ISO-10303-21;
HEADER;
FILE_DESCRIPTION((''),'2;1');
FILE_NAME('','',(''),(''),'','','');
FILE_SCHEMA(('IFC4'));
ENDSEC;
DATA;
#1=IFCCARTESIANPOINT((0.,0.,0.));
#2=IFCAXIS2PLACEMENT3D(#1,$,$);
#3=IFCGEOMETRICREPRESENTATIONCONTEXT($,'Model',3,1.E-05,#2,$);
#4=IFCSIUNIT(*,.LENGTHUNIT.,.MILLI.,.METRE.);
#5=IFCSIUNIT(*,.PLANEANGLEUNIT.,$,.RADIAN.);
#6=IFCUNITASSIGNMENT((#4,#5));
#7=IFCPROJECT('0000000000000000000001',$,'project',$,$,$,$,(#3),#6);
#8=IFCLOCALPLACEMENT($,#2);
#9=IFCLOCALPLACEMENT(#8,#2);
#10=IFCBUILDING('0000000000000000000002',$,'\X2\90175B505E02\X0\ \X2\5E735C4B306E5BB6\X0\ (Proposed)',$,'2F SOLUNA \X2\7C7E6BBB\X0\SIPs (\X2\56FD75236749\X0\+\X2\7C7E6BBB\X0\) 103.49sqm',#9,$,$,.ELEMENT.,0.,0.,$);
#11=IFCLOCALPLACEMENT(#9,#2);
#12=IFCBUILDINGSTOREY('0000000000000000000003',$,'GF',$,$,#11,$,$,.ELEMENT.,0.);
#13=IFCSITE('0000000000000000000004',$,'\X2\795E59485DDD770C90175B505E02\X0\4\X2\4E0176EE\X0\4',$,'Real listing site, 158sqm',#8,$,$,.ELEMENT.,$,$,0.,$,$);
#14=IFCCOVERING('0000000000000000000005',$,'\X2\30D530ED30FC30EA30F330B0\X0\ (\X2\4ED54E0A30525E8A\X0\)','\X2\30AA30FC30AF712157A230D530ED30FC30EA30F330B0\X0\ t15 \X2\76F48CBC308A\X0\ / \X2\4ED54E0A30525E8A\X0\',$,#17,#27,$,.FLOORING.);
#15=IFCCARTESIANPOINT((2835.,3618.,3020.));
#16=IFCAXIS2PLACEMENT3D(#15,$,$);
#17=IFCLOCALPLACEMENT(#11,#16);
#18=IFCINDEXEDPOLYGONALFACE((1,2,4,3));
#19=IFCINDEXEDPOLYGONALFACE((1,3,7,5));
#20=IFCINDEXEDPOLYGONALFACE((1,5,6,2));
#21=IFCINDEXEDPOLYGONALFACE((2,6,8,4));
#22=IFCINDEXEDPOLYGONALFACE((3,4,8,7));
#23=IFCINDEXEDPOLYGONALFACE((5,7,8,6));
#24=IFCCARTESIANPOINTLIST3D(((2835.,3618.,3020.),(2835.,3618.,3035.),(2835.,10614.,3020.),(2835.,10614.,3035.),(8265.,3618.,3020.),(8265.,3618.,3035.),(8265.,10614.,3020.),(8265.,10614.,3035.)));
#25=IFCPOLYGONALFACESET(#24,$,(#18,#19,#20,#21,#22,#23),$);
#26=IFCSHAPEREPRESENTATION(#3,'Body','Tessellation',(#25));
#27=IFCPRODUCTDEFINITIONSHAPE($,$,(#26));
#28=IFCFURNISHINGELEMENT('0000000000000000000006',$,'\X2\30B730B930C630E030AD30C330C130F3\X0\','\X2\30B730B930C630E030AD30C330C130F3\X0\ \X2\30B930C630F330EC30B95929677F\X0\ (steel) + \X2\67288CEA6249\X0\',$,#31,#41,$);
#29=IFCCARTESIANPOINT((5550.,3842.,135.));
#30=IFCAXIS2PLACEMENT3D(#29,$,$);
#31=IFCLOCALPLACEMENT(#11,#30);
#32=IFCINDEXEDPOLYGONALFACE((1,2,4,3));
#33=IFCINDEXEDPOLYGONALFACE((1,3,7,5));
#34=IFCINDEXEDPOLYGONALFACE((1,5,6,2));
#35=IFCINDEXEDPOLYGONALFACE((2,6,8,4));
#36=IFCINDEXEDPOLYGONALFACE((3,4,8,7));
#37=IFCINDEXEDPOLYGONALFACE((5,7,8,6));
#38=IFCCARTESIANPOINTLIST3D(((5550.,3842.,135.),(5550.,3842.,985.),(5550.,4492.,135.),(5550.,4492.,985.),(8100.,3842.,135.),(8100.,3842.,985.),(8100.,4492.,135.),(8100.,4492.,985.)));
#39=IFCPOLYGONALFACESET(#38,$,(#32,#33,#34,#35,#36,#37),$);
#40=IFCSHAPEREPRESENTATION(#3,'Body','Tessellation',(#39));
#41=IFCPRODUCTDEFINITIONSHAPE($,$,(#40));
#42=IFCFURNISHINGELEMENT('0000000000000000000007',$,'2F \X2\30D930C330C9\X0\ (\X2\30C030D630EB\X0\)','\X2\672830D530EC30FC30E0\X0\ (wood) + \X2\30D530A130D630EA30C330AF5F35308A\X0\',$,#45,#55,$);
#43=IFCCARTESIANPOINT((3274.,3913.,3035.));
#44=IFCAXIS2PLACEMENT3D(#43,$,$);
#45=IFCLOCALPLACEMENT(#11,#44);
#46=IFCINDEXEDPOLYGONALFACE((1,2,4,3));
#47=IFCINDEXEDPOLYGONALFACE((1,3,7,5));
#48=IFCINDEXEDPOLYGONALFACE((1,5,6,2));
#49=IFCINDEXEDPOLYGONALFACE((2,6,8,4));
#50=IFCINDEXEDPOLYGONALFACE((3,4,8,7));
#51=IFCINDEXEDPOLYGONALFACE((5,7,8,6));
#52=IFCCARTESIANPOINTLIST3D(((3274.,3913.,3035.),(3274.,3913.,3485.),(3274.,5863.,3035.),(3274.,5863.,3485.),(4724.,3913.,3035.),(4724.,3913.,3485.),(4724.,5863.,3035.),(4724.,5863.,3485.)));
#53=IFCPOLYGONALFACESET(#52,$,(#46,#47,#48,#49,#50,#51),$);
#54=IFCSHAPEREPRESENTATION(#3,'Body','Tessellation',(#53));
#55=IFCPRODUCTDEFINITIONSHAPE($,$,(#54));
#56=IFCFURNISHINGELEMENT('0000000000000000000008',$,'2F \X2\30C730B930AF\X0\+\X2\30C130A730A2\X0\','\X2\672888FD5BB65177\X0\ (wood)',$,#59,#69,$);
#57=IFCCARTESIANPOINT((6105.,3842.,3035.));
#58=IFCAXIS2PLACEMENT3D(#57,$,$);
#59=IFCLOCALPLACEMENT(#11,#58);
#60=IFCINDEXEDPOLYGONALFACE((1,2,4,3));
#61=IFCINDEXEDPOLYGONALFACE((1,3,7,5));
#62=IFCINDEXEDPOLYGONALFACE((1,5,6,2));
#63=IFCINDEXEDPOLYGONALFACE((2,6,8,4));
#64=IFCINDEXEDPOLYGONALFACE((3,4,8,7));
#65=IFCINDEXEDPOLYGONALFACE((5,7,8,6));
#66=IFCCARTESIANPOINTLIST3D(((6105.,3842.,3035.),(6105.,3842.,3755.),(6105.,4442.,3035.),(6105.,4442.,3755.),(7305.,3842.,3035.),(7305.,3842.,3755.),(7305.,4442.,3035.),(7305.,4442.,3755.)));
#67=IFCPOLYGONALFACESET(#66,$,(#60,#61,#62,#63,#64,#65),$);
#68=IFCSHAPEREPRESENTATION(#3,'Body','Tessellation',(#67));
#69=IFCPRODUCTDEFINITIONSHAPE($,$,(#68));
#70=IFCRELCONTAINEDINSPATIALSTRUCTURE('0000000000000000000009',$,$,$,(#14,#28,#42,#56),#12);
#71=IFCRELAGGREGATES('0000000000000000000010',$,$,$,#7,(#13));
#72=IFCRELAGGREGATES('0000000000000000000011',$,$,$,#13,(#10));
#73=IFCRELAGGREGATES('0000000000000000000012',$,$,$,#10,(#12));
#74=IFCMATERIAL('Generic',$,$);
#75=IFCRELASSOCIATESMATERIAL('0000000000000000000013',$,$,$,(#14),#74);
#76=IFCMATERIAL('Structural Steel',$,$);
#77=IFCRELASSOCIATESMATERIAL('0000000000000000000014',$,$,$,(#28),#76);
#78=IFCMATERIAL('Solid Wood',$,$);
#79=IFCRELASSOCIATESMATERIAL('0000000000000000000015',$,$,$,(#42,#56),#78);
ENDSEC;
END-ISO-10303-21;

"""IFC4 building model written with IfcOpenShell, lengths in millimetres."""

from ifc_helpers import new_model, si_unit, frame, frame_2d, origin, place, context, project, spatial, rectangle, extrude, material, element, save


model = new_model("IFC4")

# Units and contexts
model_context = context("Model", 3, precision=1e-05, world=origin())
ifc_project = project(units=[si_unit("LENGTHUNIT", "METRE", prefix="MILLI"), si_unit("PLANEANGLEUNIT", "RADIAN")], contexts=[model_context])

# Site, building, storey
site_placement = place(None, origin())
site = spatial("IfcSite", under=ifc_project, at=site_placement, Name="神奈川県逗子市4丁目4", ObjectType="Real listing site, 158sqm", CompositionType="ELEMENT", RefElevation=0.0)
building_placement = place(site_placement, origin())
building = spatial("IfcBuilding", under=site, at=building_placement, Name="逗子市 平屋の家 (Proposed)", ObjectType="2F SOLUNA 籾殻SIPs (国産杉+籾殻) 103.49sqm", CompositionType="ELEMENT", ElevationOfRefHeight=0.0, ElevationOfTerrain=0.0)
storey_placement = place(building_placement, origin())
storey = spatial("IfcBuildingStorey", under=building, at=storey_placement, Name="GF", CompositionType="ELEMENT", Elevation=0.0)

# Shared definitions
ifc_material_1 = material(Name="Solid Wood")

# Shared definitions
ifc_material_2 = material(Name="Generic")

# Shared definitions
ifc_material_3 = material(Name="Structural Steel")

# Covering
covering_placement = place(storey_placement, frame((2835.0, 3618.0, 3020.0)))
element("IfcCovering", 1, at=covering_placement, inside=storey, material=ifc_material_2, Name="フローリング (仕上げ床)", Description="オーク無垢フローリング t15 直貼り / 仕上げ床", PredefinedType="FLOORING", context=model_context, shape_type="SweptSolid", body=[
    extrude(rectangle(XDim=5430.0, YDim=6996.0, at=frame_2d((2715.0, 3498.0))), frame((2835.0, 3618.0, 3020.0)), (0.0, 0.0, 1.0), 15.0),
])

# Furnishing elements
furnishing_1_placement = place(storey_placement, frame((5550.0, 3842.0, 135.0)))
element("IfcFurnishingElement", 2, at=furnishing_1_placement, inside=storey, material=ifc_material_3, Name="システムキッチン", Description="システムキッチン ステンレス天板 (steel) + 木質扉", context=model_context, shape_type="SweptSolid", body=[
    extrude(rectangle(XDim=2550.0, YDim=650.0, at=frame_2d((1275.0, 325.0))), frame((5550.0, 3842.0, 135.0)), (0.0, 0.0, 1.0), 850.0),
])
furnishing_2_placement = place(storey_placement, frame((3274.0, 3913.0, 3035.0)))
element("IfcFurnishingElement", 3, at=furnishing_2_placement, inside=storey, material=ifc_material_1, Name="2F ベッド (ダブル)", Description="木フレーム (wood) + ファブリック張り", context=model_context, shape_type="SweptSolid", body=[
    extrude(rectangle(XDim=1450.0, YDim=1950.0, at=frame_2d((725.0, 975.0))), frame((3274.0, 3913.0, 3035.0)), (0.0, 0.0, 1.0), 450.0),
])
furnishing_3_placement = place(storey_placement, frame((6105.0, 3842.0, 3035.0)))
element("IfcFurnishingElement", 4, at=furnishing_3_placement, inside=storey, material=ifc_material_1, Name="2F デスク+チェア", Description="木製家具 (wood)", context=model_context, shape_type="SweptSolid", body=[
    extrude(rectangle(XDim=1200.0, YDim=600.0, at=frame_2d((600.0, 300.0))), frame((6105.0, 3842.0, 3035.0)), (0.0, 0.0, 1.0), 720.0),
])

save(model, "model.ifc")
